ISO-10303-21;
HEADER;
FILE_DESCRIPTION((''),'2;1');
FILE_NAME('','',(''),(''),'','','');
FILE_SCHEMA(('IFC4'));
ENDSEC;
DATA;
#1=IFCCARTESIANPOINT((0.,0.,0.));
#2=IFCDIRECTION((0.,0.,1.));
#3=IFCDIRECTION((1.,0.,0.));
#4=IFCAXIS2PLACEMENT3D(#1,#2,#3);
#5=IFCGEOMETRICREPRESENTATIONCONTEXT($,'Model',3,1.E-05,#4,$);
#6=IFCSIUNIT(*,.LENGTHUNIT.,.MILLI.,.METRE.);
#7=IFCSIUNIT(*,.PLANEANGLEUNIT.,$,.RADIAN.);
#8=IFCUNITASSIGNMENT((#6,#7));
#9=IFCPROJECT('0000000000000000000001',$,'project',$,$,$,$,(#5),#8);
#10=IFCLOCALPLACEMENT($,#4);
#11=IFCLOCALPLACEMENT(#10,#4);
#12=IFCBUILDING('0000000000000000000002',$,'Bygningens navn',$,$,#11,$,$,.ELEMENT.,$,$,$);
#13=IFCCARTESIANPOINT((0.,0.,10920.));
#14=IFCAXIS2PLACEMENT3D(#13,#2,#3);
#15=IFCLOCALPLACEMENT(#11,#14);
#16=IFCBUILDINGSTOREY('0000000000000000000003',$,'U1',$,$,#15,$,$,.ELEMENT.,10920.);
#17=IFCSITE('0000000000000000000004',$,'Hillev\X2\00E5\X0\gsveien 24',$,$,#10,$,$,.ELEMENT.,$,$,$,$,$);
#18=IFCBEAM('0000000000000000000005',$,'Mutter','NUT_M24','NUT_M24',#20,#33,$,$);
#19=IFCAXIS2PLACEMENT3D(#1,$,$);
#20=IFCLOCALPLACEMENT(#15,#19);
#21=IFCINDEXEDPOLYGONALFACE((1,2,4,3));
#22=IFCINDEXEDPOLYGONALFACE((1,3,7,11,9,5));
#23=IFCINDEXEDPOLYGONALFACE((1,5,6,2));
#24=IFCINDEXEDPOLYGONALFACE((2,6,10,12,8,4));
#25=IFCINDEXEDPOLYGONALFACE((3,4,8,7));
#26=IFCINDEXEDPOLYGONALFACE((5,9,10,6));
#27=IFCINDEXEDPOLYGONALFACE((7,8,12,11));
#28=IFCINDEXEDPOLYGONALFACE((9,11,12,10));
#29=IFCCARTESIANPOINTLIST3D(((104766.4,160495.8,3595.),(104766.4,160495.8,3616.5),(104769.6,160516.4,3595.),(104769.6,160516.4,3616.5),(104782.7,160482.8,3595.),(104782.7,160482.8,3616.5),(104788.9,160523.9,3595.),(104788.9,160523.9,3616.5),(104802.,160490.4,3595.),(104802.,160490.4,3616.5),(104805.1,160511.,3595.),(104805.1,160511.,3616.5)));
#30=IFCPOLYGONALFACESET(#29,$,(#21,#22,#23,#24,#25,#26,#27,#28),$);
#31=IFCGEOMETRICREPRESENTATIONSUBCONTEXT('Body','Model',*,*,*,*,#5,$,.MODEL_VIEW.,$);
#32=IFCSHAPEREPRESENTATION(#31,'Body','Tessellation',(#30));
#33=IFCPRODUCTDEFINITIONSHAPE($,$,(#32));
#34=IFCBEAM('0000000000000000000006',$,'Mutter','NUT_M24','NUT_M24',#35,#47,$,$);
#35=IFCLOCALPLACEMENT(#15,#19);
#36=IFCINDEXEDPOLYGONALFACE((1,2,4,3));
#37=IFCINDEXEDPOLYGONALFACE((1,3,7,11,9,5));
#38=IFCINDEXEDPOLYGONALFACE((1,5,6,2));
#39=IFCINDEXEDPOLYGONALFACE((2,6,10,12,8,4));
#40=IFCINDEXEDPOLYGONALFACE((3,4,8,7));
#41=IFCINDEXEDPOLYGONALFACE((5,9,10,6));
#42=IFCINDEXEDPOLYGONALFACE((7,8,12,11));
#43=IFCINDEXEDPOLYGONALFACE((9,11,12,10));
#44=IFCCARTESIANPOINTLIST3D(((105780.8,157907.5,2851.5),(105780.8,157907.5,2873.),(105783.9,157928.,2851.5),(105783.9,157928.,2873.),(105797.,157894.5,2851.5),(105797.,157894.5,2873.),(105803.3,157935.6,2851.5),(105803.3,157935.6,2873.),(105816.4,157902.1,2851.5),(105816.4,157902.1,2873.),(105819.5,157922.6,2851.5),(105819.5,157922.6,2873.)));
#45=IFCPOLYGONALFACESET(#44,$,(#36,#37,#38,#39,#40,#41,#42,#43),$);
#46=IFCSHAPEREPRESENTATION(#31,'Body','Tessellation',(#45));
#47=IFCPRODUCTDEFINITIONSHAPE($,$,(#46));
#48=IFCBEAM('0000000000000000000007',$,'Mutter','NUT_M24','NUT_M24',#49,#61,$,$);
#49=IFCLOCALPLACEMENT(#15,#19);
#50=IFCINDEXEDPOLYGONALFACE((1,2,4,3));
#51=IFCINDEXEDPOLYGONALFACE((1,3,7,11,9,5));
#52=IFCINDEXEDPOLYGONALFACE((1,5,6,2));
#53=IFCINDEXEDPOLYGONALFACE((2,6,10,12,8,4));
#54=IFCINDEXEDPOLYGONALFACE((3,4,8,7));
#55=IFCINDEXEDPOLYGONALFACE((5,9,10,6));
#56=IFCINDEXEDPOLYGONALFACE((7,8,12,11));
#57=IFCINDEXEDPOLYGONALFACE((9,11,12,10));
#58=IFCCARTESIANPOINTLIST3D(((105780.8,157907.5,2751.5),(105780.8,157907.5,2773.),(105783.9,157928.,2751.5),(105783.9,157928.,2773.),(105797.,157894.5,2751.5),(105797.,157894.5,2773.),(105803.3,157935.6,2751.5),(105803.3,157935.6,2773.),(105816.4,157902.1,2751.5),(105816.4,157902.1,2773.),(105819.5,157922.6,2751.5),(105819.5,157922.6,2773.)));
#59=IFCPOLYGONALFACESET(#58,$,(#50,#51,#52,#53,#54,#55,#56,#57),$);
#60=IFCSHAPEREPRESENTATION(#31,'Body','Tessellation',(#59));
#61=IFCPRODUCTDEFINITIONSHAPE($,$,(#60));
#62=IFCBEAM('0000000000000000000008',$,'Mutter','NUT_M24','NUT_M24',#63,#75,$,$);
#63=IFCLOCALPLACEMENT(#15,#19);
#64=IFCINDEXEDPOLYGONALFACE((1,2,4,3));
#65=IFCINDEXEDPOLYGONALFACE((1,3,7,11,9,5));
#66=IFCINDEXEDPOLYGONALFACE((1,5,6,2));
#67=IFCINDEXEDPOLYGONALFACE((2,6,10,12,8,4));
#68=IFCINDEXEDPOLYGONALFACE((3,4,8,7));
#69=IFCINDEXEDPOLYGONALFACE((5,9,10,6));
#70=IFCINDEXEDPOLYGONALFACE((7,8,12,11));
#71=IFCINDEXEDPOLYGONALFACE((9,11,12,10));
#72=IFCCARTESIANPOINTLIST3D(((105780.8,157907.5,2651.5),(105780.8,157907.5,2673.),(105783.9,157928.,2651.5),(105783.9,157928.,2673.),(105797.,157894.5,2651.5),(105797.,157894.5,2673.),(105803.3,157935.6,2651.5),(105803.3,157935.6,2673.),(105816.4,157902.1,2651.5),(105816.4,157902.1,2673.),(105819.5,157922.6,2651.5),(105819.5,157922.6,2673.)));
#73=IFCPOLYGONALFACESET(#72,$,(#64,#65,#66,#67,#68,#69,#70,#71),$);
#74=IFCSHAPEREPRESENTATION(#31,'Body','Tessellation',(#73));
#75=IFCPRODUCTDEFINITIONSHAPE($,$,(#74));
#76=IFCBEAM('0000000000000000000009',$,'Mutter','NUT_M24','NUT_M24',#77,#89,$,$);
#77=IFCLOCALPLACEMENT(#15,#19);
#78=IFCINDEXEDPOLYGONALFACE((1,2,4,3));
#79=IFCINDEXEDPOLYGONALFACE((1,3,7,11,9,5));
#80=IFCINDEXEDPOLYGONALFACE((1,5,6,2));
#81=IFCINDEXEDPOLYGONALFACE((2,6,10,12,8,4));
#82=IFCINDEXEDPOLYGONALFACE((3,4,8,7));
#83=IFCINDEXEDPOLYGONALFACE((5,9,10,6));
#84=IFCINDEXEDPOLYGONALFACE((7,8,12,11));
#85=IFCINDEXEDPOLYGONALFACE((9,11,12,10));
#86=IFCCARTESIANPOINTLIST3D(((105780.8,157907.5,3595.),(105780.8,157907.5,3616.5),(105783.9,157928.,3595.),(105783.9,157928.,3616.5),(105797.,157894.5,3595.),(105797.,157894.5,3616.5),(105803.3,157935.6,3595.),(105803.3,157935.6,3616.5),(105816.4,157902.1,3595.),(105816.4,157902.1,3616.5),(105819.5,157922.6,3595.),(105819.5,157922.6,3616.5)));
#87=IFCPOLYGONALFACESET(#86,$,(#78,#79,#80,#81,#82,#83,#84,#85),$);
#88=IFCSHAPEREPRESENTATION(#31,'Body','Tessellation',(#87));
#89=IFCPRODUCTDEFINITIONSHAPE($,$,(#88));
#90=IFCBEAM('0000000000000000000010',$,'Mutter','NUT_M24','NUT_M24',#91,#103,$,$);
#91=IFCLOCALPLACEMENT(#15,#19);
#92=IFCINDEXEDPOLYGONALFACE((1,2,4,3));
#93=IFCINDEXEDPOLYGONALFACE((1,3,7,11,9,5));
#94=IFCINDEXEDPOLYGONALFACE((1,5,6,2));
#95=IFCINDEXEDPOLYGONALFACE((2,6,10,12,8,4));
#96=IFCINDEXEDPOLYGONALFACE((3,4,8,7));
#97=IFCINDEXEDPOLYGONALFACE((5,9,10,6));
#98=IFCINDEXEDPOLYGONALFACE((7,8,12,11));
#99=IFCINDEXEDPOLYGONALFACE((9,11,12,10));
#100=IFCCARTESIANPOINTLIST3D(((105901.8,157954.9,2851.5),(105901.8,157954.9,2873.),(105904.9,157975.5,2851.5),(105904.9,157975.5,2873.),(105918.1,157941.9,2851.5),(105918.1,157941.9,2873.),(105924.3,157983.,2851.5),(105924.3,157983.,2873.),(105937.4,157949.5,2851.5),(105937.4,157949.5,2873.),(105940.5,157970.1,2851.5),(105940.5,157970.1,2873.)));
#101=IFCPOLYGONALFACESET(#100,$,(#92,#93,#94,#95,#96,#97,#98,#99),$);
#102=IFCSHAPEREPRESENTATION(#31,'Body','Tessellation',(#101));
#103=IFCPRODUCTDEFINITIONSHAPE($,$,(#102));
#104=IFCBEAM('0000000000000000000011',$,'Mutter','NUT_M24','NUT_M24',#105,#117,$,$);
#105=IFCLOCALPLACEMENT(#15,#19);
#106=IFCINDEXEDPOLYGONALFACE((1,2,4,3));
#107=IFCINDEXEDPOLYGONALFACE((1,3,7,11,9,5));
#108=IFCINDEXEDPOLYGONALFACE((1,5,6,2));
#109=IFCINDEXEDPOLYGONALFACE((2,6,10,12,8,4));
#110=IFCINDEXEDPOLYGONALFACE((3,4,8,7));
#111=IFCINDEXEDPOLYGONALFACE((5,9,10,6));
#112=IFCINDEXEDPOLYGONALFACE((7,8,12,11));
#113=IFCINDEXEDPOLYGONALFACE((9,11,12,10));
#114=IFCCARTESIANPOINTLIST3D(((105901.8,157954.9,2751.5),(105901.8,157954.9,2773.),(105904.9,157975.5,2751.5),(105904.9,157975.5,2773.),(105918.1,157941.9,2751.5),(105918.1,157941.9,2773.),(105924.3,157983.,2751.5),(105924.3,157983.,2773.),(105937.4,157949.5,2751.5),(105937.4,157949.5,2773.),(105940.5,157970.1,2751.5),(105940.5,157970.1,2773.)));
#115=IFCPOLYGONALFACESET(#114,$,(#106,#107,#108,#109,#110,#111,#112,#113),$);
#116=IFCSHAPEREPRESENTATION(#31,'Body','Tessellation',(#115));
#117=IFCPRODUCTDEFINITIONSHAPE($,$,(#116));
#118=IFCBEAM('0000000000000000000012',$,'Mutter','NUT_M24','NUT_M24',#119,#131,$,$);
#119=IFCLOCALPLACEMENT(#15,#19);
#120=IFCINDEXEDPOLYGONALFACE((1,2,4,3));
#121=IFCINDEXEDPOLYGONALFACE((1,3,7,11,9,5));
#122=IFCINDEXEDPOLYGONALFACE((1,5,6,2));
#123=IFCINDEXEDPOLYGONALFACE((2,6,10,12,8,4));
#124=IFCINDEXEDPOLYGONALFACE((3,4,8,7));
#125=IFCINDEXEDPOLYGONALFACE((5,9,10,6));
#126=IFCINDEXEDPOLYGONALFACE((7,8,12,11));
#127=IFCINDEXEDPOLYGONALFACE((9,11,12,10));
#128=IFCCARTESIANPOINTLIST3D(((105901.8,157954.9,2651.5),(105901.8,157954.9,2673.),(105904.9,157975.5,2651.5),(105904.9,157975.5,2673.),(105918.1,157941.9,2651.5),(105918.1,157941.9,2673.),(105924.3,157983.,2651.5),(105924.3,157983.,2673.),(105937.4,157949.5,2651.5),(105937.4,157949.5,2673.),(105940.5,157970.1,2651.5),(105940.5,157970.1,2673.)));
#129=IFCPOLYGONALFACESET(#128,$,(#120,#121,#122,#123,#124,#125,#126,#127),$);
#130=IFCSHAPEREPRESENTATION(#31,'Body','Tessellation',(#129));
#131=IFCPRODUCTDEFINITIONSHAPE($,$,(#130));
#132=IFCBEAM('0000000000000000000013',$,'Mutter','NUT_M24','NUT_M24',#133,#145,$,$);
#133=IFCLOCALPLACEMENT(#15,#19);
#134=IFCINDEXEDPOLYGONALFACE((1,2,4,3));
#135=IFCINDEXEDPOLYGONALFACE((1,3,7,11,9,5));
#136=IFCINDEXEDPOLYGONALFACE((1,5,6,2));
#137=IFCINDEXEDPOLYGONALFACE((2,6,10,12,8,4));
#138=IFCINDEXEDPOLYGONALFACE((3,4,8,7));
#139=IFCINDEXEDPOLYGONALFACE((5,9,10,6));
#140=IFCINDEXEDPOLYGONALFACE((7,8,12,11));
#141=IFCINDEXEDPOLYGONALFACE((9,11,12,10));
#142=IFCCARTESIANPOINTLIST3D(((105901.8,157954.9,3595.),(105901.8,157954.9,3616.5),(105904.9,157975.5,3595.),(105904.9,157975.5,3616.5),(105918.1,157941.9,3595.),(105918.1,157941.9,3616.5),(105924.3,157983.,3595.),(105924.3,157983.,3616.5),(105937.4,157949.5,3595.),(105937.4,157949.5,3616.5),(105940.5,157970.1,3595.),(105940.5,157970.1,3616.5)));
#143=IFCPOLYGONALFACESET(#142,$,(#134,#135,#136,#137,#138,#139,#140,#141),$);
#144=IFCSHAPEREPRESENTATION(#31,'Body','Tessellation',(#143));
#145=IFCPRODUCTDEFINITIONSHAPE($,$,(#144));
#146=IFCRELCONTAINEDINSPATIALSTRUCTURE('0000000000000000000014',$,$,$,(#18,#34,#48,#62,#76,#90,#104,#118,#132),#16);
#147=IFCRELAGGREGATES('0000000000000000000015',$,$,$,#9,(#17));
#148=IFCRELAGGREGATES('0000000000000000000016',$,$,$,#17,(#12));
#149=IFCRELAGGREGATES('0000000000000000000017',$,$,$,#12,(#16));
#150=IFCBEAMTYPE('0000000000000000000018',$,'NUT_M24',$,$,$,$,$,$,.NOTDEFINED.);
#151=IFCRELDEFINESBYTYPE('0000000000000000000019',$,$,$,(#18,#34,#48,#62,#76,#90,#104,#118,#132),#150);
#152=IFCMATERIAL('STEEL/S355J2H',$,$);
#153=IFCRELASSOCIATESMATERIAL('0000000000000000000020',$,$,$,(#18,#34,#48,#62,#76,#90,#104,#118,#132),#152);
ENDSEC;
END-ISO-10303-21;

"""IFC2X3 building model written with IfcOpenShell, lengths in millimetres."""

from ifc_helpers import new_model, si_unit, frame, origin_with_axes, place, context, subcontext, project, spatial, polyline, outline, extrude, material, type_object, element, save


model = new_model("IFC2X3")

# Units and contexts
model_context = context("Model", 3, precision=1e-05, world=origin_with_axes())
body_context = subcontext(model_context, "Body", "Model", "MODEL_VIEW")
ifc_project = project(units=[si_unit("LENGTHUNIT", "METRE", prefix="MILLI"), si_unit("PLANEANGLEUNIT", "RADIAN")], contexts=[model_context])

# Site, building, storey
site_placement = place(None, origin_with_axes())
site = spatial("IfcSite", under=ifc_project, at=site_placement, Name="Hillevågsveien 24", CompositionType="ELEMENT")
building_placement = place(site_placement, origin_with_axes())
building = spatial("IfcBuilding", under=site, at=building_placement, Name="Bygningens navn", CompositionType="ELEMENT")
storey_placement = place(building_placement, frame((0.0, 0.0, 10920.0), z_axis=(0.0, 0.0, 1.0), x_axis=(1.0, 0.0, 0.0)))
storey = spatial("IfcBuildingStorey", under=building, at=storey_placement, Name="U1", CompositionType="ELEMENT", Elevation=10920.0)

# Beams
ifc_material_1 = material(Name="STEEL/S355J2H")
beam_type_1 = type_object("IfcBeamType", Name="NUT_M24", PredefinedType="NOTDEFINED")
for number, where, z_axis, x_axis, name in (
    (1, (104785.8, 160503.4, 3616.5), (-0.364877, 0.931056, 0.0), (0.0, 0.0, -1.0), "Mutter"),
    (2, (105800.2, 157915.1, 2873.0), (-0.364877, 0.931056, 0.0), (0.0, 0.0, -1.0), "Mutter"),
    (3, (105800.2, 157915.1, 2773.0), (-0.364877, 0.931056, 0.0), (0.0, 0.0, -1.0), "Mutter"),
    (4, (105800.2, 157915.1, 2673.0), (-0.364877, 0.931056, 0.0), (0.0, 0.0, -1.0), "Mutter"),
    (5, (105800.2, 157915.1, 3616.5), (-0.364877, 0.931056, 0.0), (0.0, 0.0, -1.0), "Mutter"),
    (6, (105921.2, 157962.5, 2873.0), (-0.364877, 0.931056, 0.0), (0.0, 0.0, -1.0), "Mutter"),
    (7, (105921.2, 157962.5, 2773.0), (-0.364877, 0.931056, 0.0), (0.0, 0.0, -1.0), "Mutter"),
    (8, (105921.2, 157962.5, 2673.0), (-0.364877, 0.931056, 0.0), (0.0, 0.0, -1.0), "Mutter"),
    (9, (105921.2, 157962.5, 3616.5), (-0.364877, 0.931056, 0.0), (0.0, 0.0, -1.0), "Mutter"),
):
    element("IfcBeam", number, at=place(storey_placement, frame(where, z_axis=z_axis, x_axis=x_axis)), inside=storey, type_object=beam_type_1, material=ifc_material_1, Name=name, Description="NUT_M24", ObjectType="NUT_M24", context=body_context, shape_type="SweptSolid", body=[
        extrude(outline(polyline([(-10.4, 18.0), (10.4, 18.0), (20.8, 0.0), (10.4, -18.0), (-10.4, -18.0), (-20.8, 0.0), (-10.4, 18.0)])), frame((21.5, 0.0, 0.0), z_axis=(-1.0, 0.0, 0.0), x_axis=(0.0, -1.0, 0.0)), (0.0, 0.0, 1.0), 21.5),
    ])

save(model, "model.ifc")
